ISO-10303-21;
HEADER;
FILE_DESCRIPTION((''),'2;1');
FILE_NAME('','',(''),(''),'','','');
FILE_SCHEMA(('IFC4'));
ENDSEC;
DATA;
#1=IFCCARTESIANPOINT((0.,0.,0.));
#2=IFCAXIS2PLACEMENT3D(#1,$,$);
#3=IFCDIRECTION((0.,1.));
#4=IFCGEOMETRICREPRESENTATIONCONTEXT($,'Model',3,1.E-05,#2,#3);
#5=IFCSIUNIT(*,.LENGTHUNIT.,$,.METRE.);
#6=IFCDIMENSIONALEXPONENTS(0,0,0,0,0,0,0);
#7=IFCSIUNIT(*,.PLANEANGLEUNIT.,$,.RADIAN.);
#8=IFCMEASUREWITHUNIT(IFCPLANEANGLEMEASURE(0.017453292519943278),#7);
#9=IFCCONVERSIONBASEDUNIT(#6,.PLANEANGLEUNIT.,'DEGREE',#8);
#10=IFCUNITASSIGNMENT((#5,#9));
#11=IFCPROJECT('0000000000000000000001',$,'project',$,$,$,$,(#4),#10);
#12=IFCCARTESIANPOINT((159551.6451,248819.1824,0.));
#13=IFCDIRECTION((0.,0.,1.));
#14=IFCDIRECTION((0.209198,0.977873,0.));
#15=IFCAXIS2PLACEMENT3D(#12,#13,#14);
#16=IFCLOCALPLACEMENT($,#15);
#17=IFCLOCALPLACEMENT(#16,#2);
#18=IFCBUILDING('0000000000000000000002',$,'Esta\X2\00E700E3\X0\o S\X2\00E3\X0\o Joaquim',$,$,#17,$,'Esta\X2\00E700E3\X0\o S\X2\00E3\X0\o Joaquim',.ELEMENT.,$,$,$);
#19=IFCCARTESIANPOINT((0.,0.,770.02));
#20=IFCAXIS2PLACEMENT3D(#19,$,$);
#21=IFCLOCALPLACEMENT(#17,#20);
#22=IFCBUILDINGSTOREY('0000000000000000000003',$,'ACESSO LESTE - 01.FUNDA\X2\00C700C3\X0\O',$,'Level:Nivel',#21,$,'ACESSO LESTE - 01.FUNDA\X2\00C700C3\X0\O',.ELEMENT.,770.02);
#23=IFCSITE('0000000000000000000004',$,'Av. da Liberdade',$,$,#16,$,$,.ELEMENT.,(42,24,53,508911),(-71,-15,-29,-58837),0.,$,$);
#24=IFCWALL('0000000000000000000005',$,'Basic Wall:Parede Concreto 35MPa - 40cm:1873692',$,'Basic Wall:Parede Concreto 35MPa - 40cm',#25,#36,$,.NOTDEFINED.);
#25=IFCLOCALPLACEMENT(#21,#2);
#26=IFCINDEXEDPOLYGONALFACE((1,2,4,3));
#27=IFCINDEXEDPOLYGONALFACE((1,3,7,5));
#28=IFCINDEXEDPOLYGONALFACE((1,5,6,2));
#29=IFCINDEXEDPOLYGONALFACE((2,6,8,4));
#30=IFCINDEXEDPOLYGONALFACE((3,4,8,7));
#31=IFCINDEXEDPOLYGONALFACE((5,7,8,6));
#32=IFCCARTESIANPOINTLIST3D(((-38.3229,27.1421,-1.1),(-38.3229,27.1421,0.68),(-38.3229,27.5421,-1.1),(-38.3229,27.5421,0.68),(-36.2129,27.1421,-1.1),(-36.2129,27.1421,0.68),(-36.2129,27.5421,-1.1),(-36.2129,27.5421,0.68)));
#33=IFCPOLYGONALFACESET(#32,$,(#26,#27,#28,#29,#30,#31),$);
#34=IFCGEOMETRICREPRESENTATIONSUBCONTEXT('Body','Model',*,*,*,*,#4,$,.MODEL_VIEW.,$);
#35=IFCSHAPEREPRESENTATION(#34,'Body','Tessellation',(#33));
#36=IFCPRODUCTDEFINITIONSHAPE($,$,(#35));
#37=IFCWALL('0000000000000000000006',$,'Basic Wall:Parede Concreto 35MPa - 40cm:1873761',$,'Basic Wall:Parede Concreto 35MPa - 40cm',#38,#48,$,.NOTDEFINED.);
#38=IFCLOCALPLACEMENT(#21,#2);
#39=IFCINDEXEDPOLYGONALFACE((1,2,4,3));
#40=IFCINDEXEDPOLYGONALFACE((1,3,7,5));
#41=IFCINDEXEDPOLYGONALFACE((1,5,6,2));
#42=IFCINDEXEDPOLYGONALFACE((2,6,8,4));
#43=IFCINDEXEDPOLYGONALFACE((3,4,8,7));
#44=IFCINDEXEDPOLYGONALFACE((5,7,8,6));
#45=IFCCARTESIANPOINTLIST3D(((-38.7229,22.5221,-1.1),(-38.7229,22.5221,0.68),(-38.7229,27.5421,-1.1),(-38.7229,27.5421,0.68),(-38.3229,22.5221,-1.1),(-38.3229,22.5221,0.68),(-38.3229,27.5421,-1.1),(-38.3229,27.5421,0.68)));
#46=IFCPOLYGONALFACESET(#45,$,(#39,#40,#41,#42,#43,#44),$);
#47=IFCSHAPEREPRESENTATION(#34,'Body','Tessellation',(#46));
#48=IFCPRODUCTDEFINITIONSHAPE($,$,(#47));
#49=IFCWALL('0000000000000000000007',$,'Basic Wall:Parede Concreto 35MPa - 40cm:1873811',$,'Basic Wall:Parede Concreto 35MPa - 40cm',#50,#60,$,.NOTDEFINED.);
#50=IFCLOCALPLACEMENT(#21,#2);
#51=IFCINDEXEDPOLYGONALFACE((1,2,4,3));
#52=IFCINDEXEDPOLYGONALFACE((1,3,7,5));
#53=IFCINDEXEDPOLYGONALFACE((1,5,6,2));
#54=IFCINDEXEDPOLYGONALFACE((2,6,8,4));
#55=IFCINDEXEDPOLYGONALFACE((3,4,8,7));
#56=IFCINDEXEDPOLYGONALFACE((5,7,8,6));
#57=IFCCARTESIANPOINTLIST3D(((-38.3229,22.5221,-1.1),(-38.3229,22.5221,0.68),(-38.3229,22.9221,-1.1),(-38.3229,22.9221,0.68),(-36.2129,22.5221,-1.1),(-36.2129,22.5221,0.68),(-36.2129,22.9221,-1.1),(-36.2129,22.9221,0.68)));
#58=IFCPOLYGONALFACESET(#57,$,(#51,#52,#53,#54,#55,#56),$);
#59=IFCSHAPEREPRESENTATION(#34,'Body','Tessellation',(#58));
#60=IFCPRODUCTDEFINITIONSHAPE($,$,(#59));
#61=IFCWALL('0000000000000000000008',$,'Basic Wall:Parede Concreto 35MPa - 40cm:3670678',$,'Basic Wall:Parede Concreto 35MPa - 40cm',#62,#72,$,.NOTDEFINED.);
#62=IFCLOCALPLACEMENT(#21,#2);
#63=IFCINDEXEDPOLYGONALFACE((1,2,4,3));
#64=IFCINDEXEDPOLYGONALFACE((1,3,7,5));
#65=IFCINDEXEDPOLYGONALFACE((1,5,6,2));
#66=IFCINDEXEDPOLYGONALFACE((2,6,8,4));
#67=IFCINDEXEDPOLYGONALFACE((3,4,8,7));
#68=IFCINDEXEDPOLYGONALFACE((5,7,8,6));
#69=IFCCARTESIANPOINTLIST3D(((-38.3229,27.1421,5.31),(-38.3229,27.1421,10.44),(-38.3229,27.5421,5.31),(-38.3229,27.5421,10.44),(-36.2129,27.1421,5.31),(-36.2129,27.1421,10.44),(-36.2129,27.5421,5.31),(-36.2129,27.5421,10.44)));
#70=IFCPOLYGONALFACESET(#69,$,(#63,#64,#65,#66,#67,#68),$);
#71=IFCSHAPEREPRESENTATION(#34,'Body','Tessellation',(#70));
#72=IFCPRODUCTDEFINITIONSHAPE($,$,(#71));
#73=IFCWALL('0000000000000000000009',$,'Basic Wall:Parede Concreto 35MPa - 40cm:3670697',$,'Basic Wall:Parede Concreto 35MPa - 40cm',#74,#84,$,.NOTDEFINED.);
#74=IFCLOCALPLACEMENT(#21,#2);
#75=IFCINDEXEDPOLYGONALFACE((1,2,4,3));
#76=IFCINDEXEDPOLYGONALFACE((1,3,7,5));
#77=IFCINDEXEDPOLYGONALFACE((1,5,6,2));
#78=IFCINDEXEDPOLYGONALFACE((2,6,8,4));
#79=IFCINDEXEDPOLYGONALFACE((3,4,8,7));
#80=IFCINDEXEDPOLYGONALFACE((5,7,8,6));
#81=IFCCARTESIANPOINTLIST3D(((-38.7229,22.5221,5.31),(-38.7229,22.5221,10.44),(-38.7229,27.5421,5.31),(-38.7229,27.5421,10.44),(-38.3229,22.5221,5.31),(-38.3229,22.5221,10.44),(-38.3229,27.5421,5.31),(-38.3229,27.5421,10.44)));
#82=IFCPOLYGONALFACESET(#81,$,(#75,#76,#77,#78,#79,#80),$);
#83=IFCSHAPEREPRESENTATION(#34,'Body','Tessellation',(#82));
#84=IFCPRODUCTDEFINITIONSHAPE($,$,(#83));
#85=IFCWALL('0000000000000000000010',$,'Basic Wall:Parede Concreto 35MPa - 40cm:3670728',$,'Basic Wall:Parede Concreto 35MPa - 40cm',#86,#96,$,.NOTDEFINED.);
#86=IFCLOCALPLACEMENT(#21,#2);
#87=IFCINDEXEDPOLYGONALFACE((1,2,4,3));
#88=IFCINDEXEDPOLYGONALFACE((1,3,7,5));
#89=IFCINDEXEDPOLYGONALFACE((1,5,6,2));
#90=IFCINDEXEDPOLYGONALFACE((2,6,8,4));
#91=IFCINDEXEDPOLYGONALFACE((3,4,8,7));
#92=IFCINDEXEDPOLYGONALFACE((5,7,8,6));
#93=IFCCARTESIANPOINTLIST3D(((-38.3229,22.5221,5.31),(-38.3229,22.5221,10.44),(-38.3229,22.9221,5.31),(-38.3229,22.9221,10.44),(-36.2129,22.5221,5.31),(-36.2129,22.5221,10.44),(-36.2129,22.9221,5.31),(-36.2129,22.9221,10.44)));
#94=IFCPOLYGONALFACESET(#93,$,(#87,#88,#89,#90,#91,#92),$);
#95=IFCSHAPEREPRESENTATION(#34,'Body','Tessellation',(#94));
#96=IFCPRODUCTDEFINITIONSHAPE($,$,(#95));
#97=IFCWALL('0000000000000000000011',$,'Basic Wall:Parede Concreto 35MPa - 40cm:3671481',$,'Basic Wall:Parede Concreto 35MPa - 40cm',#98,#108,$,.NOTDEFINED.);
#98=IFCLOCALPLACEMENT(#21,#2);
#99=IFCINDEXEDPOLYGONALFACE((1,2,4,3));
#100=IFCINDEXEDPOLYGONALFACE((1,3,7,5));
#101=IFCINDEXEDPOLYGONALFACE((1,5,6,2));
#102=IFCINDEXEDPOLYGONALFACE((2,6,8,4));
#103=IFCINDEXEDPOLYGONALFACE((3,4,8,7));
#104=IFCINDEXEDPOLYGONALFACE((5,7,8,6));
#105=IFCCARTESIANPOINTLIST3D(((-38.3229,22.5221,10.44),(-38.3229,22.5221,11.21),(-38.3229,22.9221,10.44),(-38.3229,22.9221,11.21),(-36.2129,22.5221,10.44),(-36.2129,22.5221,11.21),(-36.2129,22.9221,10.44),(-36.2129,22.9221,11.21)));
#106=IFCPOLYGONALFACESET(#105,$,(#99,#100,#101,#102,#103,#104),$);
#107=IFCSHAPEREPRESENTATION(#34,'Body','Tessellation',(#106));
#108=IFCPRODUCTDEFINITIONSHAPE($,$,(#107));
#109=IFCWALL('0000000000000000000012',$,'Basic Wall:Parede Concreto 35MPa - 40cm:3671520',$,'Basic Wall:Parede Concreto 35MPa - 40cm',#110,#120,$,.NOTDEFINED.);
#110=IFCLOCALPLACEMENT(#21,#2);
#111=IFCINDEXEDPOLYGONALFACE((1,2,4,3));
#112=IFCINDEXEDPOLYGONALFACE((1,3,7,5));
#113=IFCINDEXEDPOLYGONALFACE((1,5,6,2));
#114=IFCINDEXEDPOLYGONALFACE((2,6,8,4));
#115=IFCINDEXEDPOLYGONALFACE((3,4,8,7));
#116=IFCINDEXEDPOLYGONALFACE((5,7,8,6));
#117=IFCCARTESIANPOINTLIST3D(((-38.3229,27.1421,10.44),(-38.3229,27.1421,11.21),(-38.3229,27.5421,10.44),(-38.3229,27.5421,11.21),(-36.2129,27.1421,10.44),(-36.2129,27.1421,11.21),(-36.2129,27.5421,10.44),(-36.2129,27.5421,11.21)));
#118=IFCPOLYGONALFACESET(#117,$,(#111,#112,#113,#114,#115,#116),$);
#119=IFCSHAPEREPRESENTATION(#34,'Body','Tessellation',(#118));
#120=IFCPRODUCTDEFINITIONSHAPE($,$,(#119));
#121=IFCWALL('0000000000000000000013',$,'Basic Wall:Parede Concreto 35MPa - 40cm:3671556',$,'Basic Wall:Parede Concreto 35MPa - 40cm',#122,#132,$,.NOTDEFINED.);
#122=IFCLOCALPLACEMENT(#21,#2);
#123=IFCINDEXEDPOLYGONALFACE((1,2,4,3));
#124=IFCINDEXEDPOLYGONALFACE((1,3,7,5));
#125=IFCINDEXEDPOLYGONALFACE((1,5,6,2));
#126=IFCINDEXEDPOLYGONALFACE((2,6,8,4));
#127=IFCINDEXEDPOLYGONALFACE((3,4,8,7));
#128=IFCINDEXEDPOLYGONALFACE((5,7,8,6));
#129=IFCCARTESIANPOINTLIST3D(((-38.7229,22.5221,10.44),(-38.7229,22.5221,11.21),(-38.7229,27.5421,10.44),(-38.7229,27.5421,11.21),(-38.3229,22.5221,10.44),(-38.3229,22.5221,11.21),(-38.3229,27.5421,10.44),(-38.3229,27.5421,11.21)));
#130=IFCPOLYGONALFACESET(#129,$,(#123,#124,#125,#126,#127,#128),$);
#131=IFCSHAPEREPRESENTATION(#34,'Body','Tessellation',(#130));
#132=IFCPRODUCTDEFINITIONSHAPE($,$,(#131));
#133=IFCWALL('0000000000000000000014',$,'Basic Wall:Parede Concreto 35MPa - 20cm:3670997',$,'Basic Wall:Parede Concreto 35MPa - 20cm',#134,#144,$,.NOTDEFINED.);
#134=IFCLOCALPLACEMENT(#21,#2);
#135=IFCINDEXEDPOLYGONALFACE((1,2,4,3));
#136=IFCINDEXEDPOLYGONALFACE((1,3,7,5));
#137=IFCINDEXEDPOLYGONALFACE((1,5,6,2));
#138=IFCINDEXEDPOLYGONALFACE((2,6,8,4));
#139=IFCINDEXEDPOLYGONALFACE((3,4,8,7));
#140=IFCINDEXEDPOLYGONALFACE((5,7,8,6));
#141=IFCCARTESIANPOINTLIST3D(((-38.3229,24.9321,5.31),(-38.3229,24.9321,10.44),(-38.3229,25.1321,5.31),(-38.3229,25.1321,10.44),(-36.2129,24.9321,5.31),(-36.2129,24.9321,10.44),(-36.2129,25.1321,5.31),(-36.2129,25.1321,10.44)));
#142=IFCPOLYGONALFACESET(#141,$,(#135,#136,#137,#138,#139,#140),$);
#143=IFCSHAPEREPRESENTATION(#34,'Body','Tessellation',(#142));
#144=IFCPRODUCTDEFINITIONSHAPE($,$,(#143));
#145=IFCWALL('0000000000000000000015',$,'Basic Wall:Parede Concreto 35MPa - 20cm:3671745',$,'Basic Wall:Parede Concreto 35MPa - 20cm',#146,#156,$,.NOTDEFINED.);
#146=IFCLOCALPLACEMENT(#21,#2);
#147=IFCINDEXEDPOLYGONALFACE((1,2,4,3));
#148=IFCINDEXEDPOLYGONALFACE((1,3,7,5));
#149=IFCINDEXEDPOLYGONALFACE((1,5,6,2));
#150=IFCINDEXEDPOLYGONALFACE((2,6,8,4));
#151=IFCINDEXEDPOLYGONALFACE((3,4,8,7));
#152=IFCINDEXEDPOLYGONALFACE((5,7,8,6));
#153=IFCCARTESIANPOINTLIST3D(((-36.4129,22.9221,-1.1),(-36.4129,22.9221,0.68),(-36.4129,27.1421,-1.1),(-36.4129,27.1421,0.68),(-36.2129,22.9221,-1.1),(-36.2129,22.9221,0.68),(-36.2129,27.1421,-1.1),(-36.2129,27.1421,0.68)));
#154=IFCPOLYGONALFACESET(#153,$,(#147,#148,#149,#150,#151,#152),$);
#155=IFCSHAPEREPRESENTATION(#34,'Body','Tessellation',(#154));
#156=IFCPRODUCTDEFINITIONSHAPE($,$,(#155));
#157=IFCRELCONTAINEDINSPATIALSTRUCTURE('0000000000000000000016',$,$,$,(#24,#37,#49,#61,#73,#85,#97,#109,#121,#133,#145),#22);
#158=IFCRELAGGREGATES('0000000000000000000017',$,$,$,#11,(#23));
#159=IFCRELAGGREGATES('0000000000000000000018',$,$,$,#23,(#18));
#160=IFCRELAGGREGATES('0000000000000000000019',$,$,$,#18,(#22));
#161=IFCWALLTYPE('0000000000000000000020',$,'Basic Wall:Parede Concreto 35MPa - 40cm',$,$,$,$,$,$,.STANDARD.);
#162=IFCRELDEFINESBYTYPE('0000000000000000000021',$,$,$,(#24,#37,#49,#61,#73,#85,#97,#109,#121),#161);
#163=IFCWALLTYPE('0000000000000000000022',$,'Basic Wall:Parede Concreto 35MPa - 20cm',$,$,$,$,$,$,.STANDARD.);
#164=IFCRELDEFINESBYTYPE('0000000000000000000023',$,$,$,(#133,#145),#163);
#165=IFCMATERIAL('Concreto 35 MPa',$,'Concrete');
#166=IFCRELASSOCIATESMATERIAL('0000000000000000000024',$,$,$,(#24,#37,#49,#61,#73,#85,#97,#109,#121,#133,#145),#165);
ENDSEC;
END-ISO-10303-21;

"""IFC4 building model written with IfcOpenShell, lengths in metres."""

from ifc_helpers import new_model, entity, si_unit, converted_unit, direction, frame, origin, place, context, subcontext, project, spatial, indexed_curve, outline, extrude, material, type_object, element, save


model = new_model("IFC4")

# Units and contexts
model_context = context("Model", 3, precision=1e-05, world=origin(), true_north=direction((0.0, 1.0)))
body_context = subcontext(model_context, "Body", "Model", "MODEL_VIEW")
ifc_project = project(units=[si_unit("LENGTHUNIT", "METRE"), converted_unit("PLANEANGLEUNIT", "DEGREE", entity("IfcPlaneAngleMeasure", 0.017453292519943278), si_unit("PLANEANGLEUNIT", "RADIAN"), dimensions=[0, 0, 0, 0, 0, 0, 0])], contexts=[model_context])

# Site, building, storey
site_placement = place(None, frame((159551.6451, 248819.1824, 0.0), z_axis=(0.0, 0.0, 1.0), x_axis=(0.209198, 0.977873, 0.0)))
site = spatial("IfcSite", under=ifc_project, at=site_placement, Name="Av. da Liberdade", CompositionType="ELEMENT", RefLatitude=(42, 24, 53, 508911), RefLongitude=(-71, -15, -29, -58837), RefElevation=0.0)
building_placement = place(site_placement, origin())
building = spatial("IfcBuilding", under=site, at=building_placement, Name="Estação São Joaquim", LongName="Estação São Joaquim", CompositionType="ELEMENT")
storey_placement = place(building_placement, frame((0.0, 0.0, 770.02)))
storey = spatial("IfcBuildingStorey", under=building, at=storey_placement, Name="ACESSO LESTE - 01.FUNDAÇÃO", ObjectType="Level:Nivel", LongName="ACESSO LESTE - 01.FUNDAÇÃO", CompositionType="ELEMENT", Elevation=770.02)

# Shared definitions
ifc_material_1 = material(Name="Concreto 35 MPa", Category="Concrete")

# Walls
wall_type_1 = type_object("IfcWallType", Name="Basic Wall:Parede Concreto 35MPa - 40cm", PredefinedType="STANDARD")
wall_1_placement = place(storey_placement, frame((-36.2129, 27.3421, -1.1), z_axis=(0.0, 0.0, 1.0), x_axis=(-1.0, 0.0, 0.0)))
element("IfcWall", 1, at=wall_1_placement, inside=storey, type_object=wall_type_1, material=ifc_material_1, Name="Basic Wall:Parede Concreto 35MPa - 40cm:1873692", ObjectType="Basic Wall:Parede Concreto 35MPa - 40cm", PredefinedType="NOTDEFINED", context=body_context, shape_type="SweptSolid", body=[
    extrude(outline(indexed_curve([(2.11, 0.2), (0.0, 0.2), (0.0, -0.2), (2.11, -0.2), (2.11, 0.2)], self_intersect=False)), origin(), (0.0, 0.0, 1.0), 1.78),
])
wall_2_placement = place(storey_placement, frame((-38.5229, 27.5421, -1.1), z_axis=(0.0, 0.0, 1.0), x_axis=(0.0, -1.0, 0.0)))
element("IfcWall", 2, at=wall_2_placement, inside=storey, type_object=wall_type_1, material=ifc_material_1, Name="Basic Wall:Parede Concreto 35MPa - 40cm:1873761", ObjectType="Basic Wall:Parede Concreto 35MPa - 40cm", PredefinedType="NOTDEFINED", context=body_context, shape_type="SweptSolid", body=[
    extrude(outline(indexed_curve([(5.0201, 0.2), (0.0, 0.2), (0.0, -0.2), (5.0201, -0.2), (5.0201, 0.2)], self_intersect=False)), origin(), (0.0, 0.0, 1.0), 1.78),
])
wall_3_placement = place(storey_placement, frame((-38.3229, 22.7221, -1.1)))
element("IfcWall", 3, at=wall_3_placement, inside=storey, type_object=wall_type_1, material=ifc_material_1, Name="Basic Wall:Parede Concreto 35MPa - 40cm:1873811", ObjectType="Basic Wall:Parede Concreto 35MPa - 40cm", PredefinedType="NOTDEFINED", context=body_context, shape_type="SweptSolid", body=[
    extrude(outline(indexed_curve([(2.11, 0.2), (0.0, 0.2), (0.0, -0.2), (2.11, -0.2), (2.11, 0.2)], self_intersect=False)), origin(), (0.0, 0.0, 1.0), 1.78),
])
wall_4_placement = place(storey_placement, frame((-36.2129, 27.3421, 5.31), z_axis=(0.0, 0.0, 1.0), x_axis=(-1.0, 0.0, 0.0)))
element("IfcWall", 4, at=wall_4_placement, inside=storey, type_object=wall_type_1, material=ifc_material_1, Name="Basic Wall:Parede Concreto 35MPa - 40cm:3670678", ObjectType="Basic Wall:Parede Concreto 35MPa - 40cm", PredefinedType="NOTDEFINED", context=body_context, shape_type="SweptSolid", body=[
    extrude(outline(indexed_curve([(2.11, 0.2), (0.0, 0.2), (0.0, -0.2), (2.11, -0.2), (2.11, 0.2)], self_intersect=False)), origin(), (0.0, 0.0, 1.0), 5.13),
])
wall_5_placement = place(storey_placement, frame((-38.5229, 27.5421, 5.31), z_axis=(0.0, 0.0, 1.0), x_axis=(0.0, -1.0, 0.0)))
element("IfcWall", 5, at=wall_5_placement, inside=storey, type_object=wall_type_1, material=ifc_material_1, Name="Basic Wall:Parede Concreto 35MPa - 40cm:3670697", ObjectType="Basic Wall:Parede Concreto 35MPa - 40cm", PredefinedType="NOTDEFINED", context=body_context, shape_type="SweptSolid", body=[
    extrude(outline(indexed_curve([(5.0201, 0.2), (0.0, 0.2), (0.0, -0.2), (5.0201, -0.2), (5.0201, 0.2)], self_intersect=False)), origin(), (0.0, 0.0, 1.0), 5.13),
])
wall_6_placement = place(storey_placement, frame((-38.3229, 22.7221, 5.31)))
element("IfcWall", 6, at=wall_6_placement, inside=storey, type_object=wall_type_1, material=ifc_material_1, Name="Basic Wall:Parede Concreto 35MPa - 40cm:3670728", ObjectType="Basic Wall:Parede Concreto 35MPa - 40cm", PredefinedType="NOTDEFINED", context=body_context, shape_type="SweptSolid", body=[
    extrude(outline(indexed_curve([(2.11, 0.2), (0.0, 0.2), (0.0, -0.2), (2.11, -0.2), (2.11, 0.2)], self_intersect=False)), origin(), (0.0, 0.0, 1.0), 5.13),
])
wall_7_placement = place(storey_placement, frame((-38.3229, 22.7221, 10.44)))
element("IfcWall", 7, at=wall_7_placement, inside=storey, type_object=wall_type_1, material=ifc_material_1, Name="Basic Wall:Parede Concreto 35MPa - 40cm:3671481", ObjectType="Basic Wall:Parede Concreto 35MPa - 40cm", PredefinedType="NOTDEFINED", context=body_context, shape_type="SweptSolid", body=[
    extrude(outline(indexed_curve([(2.11, 0.2), (0.0, 0.2), (0.0, -0.2), (2.11, -0.2), (2.11, 0.2)], self_intersect=False)), origin(), (0.0, 0.0, 1.0), 0.77),
])
wall_8_placement = place(storey_placement, frame((-36.2129, 27.3421, 10.44), z_axis=(0.0, 0.0, 1.0), x_axis=(-1.0, 0.0, 0.0)))
element("IfcWall", 8, at=wall_8_placement, inside=storey, type_object=wall_type_1, material=ifc_material_1, Name="Basic Wall:Parede Concreto 35MPa - 40cm:3671520", ObjectType="Basic Wall:Parede Concreto 35MPa - 40cm", PredefinedType="NOTDEFINED", context=body_context, shape_type="SweptSolid", body=[
    extrude(outline(indexed_curve([(2.11, 0.2), (0.0, 0.2), (0.0, -0.2), (2.11, -0.2), (2.11, 0.2)], self_intersect=False)), origin(), (0.0, 0.0, 1.0), 0.77),
])
wall_9_placement = place(storey_placement, frame((-38.5229, 27.5421, 10.44), z_axis=(0.0, 0.0, 1.0), x_axis=(0.0, -1.0, 0.0)))
element("IfcWall", 9, at=wall_9_placement, inside=storey, type_object=wall_type_1, material=ifc_material_1, Name="Basic Wall:Parede Concreto 35MPa - 40cm:3671556", ObjectType="Basic Wall:Parede Concreto 35MPa - 40cm", PredefinedType="NOTDEFINED", context=body_context, shape_type="SweptSolid", body=[
    extrude(outline(indexed_curve([(5.0201, 0.2), (0.0, 0.2), (0.0, -0.2), (5.0201, -0.2), (5.0201, 0.2)], self_intersect=False)), origin(), (0.0, 0.0, 1.0), 0.77),
])
wall_type_2 = type_object("IfcWallType", Name="Basic Wall:Parede Concreto 35MPa - 20cm", PredefinedType="STANDARD")
wall_10_placement = place(storey_placement, frame((-36.2129, 25.0321, 5.31), z_axis=(0.0, 0.0, 1.0), x_axis=(-1.0, 0.0, 0.0)))
element("IfcWall", 10, at=wall_10_placement, inside=storey, type_object=wall_type_2, material=ifc_material_1, Name="Basic Wall:Parede Concreto 35MPa - 20cm:3670997", ObjectType="Basic Wall:Parede Concreto 35MPa - 20cm", PredefinedType="NOTDEFINED", context=body_context, shape_type="SweptSolid", body=[
    extrude(outline(indexed_curve([(2.11, 0.1), (0.0, 0.1), (0.0, -0.1), (2.11, -0.1), (2.11, 0.1)], self_intersect=False)), origin(), (0.0, 0.0, 1.0), 5.13),
])
wall_11_placement = place(storey_placement, frame((-36.3129, 27.1421, -1.1), z_axis=(0.0, 0.0, 1.0), x_axis=(0.0, -1.0, 0.0)))
element("IfcWall", 11, at=wall_11_placement, inside=storey, type_object=wall_type_2, material=ifc_material_1, Name="Basic Wall:Parede Concreto 35MPa - 20cm:3671745", ObjectType="Basic Wall:Parede Concreto 35MPa - 20cm", PredefinedType="NOTDEFINED", context=body_context, shape_type="SweptSolid", body=[
    extrude(outline(indexed_curve([(4.2201, 0.1), (0.0, 0.1), (0.0, -0.1), (4.2201, -0.1), (4.2201, 0.1)], self_intersect=False)), origin(), (0.0, 0.0, 1.0), 1.78),
])

save(model, "model.ifc")
